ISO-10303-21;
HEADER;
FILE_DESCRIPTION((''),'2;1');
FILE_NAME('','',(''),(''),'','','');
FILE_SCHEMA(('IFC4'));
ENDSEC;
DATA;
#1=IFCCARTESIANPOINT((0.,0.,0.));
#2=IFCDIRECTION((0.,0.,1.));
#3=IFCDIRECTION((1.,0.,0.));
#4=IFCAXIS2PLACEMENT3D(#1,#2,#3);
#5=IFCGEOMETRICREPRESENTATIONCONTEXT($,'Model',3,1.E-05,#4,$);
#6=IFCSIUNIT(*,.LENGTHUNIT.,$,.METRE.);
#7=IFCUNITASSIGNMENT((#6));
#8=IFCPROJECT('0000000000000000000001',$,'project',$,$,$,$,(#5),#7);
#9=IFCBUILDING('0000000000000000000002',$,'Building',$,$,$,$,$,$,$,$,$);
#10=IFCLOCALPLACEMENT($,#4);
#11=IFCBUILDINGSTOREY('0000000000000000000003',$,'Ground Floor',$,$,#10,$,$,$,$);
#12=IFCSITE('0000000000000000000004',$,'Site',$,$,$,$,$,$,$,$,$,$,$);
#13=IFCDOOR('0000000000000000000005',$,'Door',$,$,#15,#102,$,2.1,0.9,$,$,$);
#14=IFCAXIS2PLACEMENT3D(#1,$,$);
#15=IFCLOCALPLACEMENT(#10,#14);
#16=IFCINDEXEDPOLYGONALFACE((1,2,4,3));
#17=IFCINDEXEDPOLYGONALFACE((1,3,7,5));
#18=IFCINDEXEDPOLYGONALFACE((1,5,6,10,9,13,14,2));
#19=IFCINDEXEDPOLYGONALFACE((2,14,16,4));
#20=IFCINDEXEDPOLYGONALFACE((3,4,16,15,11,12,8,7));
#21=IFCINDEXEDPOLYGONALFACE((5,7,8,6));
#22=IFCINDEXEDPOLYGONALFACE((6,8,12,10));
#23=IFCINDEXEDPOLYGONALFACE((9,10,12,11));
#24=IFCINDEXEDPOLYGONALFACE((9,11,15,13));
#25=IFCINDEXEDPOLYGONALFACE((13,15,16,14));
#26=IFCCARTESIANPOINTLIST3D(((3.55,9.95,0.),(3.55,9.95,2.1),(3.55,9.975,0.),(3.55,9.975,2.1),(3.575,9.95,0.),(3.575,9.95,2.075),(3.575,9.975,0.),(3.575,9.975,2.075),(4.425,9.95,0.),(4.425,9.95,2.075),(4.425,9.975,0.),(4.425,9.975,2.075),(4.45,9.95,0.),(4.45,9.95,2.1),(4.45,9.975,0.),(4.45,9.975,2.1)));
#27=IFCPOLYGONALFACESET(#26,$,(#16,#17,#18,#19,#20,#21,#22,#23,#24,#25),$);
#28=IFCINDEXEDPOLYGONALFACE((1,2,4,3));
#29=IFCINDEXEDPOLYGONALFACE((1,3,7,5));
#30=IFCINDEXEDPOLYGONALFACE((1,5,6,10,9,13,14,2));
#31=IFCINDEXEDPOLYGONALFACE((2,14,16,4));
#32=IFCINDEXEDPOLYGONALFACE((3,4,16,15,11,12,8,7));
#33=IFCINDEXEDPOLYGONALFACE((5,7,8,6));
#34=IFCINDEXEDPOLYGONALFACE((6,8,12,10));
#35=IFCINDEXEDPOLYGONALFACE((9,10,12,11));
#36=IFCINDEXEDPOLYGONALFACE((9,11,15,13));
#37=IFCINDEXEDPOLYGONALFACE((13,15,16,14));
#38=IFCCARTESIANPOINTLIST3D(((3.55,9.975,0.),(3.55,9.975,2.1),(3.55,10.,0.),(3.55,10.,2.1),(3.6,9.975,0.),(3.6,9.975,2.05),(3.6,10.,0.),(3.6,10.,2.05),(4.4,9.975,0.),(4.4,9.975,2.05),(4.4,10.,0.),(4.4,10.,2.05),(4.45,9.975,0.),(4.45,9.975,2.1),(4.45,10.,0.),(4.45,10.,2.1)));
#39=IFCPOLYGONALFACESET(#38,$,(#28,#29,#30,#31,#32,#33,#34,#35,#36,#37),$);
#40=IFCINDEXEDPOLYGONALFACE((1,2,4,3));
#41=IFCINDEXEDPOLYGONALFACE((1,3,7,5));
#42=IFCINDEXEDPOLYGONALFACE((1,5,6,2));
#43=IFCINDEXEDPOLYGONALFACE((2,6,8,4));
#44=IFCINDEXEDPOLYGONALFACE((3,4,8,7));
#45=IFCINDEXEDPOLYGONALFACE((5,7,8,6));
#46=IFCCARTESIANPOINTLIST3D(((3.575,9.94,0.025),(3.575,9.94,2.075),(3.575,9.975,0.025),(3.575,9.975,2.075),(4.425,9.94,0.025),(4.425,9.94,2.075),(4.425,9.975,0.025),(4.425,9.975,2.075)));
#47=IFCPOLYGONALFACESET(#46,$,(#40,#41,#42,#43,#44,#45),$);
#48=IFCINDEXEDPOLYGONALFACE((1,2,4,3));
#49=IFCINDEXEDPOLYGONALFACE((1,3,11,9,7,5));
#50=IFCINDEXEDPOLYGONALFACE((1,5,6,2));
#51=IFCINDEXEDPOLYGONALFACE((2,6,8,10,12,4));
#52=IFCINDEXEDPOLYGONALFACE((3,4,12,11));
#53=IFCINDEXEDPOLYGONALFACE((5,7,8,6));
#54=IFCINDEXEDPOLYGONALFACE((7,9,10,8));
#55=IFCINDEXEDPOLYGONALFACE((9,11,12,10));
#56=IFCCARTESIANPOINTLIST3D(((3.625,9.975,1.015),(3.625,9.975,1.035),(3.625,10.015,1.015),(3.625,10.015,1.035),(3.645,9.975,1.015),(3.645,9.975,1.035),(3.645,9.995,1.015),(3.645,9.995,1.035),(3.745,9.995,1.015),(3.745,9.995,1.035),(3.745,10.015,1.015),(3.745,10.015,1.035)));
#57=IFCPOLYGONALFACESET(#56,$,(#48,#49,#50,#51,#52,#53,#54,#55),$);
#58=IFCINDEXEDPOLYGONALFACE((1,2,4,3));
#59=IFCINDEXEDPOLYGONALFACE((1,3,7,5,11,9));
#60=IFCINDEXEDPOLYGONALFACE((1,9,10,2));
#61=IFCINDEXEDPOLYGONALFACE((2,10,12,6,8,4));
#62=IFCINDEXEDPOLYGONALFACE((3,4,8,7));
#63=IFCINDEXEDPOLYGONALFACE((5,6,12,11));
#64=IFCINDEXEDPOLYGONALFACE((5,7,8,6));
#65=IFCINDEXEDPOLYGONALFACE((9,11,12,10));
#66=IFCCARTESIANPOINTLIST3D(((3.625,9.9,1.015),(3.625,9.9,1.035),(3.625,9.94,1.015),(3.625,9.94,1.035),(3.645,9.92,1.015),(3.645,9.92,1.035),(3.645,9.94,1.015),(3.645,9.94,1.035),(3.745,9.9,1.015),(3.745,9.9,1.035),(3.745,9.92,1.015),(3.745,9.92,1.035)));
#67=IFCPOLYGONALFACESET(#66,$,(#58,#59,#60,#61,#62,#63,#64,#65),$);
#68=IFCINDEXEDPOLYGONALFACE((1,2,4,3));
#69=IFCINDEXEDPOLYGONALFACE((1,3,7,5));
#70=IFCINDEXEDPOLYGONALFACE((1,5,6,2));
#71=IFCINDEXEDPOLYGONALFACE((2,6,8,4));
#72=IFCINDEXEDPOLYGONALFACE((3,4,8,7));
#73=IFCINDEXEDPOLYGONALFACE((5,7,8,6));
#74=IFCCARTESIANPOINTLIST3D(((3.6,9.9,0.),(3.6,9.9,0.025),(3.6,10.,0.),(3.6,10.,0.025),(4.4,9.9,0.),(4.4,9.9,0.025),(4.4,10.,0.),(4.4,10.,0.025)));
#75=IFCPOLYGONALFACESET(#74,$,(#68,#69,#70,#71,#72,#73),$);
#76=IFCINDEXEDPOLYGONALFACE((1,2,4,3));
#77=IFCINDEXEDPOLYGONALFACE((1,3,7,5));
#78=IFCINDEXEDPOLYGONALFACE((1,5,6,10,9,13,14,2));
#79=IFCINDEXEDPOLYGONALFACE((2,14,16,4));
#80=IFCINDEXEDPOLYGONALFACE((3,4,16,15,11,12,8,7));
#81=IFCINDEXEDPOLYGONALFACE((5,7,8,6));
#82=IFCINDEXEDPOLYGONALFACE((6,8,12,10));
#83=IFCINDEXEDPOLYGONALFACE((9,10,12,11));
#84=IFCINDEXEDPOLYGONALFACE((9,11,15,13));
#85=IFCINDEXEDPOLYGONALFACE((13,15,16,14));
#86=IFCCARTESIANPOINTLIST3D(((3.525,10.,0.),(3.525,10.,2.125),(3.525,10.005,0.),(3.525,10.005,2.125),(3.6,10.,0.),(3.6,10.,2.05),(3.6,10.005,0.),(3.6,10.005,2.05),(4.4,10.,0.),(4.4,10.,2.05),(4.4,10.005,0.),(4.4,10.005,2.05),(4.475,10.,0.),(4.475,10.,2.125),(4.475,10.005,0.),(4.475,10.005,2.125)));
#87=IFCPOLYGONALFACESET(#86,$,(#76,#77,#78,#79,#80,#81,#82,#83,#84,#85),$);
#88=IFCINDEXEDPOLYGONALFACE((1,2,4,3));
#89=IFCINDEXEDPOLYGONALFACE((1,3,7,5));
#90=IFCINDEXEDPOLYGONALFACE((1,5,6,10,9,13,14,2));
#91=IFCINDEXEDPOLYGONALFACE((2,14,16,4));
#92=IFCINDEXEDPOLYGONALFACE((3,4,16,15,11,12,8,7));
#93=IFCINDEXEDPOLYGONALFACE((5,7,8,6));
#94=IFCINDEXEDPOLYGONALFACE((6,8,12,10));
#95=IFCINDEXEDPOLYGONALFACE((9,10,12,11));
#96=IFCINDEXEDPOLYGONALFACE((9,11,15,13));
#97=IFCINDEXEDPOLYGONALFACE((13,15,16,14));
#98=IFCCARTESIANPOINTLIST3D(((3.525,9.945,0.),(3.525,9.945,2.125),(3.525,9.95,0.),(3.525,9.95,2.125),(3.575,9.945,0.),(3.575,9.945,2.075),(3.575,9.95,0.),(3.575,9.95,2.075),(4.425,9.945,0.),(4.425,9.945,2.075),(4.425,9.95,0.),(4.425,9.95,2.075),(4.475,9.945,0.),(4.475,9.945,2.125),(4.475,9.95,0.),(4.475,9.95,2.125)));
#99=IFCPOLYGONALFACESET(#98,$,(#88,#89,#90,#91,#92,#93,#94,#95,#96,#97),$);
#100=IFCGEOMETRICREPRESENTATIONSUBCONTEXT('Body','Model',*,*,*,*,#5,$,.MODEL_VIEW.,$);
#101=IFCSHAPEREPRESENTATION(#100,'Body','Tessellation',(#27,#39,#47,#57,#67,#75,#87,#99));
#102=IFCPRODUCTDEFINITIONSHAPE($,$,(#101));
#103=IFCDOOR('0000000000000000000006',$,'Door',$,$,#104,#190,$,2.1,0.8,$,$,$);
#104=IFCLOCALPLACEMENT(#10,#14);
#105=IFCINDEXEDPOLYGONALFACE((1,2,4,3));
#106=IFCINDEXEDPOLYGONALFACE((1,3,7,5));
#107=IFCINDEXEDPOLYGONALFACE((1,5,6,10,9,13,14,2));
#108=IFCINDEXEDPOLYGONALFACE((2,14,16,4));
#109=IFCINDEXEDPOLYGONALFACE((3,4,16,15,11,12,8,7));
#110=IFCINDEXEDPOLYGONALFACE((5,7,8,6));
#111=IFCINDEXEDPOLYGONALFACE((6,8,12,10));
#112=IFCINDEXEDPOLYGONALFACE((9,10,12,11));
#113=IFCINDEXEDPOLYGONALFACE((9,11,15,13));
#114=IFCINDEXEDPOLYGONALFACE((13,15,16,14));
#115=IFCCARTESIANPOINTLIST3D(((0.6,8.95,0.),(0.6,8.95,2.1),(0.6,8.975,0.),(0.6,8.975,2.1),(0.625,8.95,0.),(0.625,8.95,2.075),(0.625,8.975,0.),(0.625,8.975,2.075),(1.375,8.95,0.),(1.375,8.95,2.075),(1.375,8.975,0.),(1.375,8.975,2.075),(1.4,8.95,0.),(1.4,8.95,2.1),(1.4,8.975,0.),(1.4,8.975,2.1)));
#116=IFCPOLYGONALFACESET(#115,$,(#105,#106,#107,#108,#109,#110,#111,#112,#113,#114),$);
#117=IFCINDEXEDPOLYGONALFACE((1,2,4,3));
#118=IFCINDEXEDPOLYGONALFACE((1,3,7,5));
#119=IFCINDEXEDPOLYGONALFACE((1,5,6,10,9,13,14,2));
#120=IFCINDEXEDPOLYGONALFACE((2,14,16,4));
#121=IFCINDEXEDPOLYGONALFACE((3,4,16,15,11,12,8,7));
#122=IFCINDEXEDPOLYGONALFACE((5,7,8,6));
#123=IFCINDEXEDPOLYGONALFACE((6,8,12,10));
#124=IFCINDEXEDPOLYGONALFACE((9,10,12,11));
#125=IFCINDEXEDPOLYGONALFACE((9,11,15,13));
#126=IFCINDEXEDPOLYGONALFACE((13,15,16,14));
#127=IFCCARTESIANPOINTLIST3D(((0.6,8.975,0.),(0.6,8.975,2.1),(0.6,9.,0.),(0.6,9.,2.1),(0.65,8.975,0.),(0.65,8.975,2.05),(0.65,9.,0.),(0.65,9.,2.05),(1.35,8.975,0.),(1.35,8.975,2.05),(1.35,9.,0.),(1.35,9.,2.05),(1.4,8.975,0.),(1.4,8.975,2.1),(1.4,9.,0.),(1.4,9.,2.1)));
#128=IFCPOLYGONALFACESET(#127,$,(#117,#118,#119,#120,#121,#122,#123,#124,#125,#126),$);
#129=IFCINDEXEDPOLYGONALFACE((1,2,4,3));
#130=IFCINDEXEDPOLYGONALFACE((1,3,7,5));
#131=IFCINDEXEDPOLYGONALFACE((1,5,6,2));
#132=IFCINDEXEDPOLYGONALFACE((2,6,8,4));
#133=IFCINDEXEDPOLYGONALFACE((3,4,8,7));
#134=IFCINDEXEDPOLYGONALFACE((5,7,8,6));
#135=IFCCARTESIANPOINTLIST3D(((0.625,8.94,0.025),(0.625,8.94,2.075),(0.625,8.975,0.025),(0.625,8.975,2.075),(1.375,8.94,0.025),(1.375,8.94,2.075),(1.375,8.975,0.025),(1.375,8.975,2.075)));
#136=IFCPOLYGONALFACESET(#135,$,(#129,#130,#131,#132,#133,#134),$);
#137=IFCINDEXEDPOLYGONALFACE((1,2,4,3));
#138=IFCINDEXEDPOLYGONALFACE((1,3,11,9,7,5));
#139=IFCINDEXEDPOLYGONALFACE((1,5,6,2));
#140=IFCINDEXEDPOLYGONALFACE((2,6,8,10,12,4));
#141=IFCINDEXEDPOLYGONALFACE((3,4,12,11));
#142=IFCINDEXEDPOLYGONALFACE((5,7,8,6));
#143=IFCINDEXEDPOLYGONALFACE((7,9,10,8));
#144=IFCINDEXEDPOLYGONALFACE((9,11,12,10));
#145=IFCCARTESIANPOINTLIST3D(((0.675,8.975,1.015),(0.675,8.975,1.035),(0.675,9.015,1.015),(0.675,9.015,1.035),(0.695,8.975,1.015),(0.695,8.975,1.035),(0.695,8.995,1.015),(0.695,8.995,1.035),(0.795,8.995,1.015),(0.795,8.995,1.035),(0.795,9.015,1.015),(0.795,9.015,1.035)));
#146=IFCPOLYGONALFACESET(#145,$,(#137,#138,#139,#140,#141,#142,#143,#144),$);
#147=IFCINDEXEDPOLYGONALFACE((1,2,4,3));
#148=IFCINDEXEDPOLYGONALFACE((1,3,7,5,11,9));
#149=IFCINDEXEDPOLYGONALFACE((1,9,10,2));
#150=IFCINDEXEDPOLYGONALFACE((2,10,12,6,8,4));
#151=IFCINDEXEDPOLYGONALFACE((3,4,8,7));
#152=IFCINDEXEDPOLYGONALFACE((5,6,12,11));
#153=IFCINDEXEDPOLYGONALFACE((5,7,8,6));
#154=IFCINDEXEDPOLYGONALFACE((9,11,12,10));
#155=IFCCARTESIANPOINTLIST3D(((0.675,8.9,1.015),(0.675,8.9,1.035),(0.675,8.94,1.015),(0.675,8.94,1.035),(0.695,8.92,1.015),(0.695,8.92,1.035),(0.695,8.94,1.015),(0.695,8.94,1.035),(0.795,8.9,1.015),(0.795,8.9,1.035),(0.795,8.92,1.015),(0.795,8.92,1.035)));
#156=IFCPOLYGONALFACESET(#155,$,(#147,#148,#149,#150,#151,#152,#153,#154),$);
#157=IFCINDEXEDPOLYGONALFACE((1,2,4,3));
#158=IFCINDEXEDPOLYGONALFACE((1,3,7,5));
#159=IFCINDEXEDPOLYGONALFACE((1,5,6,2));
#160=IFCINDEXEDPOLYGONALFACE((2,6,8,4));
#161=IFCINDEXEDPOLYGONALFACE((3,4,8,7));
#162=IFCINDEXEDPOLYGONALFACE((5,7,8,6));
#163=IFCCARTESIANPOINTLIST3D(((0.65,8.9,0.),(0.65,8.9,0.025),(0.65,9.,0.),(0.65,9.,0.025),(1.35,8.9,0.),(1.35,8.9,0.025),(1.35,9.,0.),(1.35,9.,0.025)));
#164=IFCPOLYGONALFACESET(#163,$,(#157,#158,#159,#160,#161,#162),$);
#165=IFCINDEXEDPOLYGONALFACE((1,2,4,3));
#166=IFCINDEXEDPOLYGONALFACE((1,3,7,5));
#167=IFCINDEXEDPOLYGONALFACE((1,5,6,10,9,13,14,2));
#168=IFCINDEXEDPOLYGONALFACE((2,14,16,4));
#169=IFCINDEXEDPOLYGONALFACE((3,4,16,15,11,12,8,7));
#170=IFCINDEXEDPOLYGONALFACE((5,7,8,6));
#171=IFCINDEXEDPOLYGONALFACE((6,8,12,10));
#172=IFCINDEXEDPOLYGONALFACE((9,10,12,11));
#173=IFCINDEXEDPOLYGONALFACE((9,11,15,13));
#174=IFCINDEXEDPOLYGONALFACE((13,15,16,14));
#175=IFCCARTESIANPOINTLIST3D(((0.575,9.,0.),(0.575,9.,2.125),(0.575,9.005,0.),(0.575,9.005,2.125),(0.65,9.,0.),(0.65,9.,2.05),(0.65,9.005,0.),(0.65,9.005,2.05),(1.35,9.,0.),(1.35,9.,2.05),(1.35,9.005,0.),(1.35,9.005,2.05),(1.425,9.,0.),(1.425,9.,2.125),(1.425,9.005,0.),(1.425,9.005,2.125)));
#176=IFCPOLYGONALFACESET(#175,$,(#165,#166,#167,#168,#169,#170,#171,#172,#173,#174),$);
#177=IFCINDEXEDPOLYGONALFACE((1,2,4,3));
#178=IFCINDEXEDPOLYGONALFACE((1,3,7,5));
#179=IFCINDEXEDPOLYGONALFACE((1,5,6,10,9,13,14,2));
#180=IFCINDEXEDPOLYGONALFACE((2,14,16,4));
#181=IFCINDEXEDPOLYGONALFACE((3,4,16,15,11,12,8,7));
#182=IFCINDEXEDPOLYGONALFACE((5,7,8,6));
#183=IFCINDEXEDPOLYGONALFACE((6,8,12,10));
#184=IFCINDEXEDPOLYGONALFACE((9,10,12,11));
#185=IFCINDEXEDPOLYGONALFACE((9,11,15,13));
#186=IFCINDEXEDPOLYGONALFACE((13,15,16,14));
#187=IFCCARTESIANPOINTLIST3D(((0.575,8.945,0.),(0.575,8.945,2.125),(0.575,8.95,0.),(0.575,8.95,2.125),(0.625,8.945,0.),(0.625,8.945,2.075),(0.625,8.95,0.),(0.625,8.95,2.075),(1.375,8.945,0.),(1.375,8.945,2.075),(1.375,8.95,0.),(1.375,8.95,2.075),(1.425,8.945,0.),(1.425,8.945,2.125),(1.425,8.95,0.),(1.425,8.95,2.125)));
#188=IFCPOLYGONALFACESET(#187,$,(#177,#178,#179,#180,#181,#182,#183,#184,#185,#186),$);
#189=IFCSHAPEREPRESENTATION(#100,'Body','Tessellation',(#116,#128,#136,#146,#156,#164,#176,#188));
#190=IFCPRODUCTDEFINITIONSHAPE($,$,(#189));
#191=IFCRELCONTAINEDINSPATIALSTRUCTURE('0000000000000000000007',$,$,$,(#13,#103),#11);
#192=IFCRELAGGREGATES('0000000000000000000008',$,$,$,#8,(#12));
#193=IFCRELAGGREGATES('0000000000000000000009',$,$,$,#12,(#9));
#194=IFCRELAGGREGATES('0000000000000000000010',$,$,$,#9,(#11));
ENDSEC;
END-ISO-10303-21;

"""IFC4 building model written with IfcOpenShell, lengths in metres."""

from ifc_helpers import new_model, si_unit, frame, origin_with_axes, place, context, subcontext, project, spatial, line, indexed_curve, outline, extrude, element, save


model = new_model("IFC4")

# Units and contexts
model_context = context("Model", 3, precision=1e-05, world=origin_with_axes())
body_context = subcontext(model_context, "Body", "Model", "MODEL_VIEW")
ifc_project = project(units=[si_unit("LENGTHUNIT", "METRE")], contexts=[model_context])

# Site, building, storey
site = spatial("IfcSite", under=ifc_project, Name="Site")
building = spatial("IfcBuilding", under=site, Name="Building")
storey_placement = place(None, origin_with_axes())
storey = spatial("IfcBuildingStorey", under=building, at=storey_placement, Name="Ground Floor")

# Doors
door_1_placement = place(storey_placement, frame((4.45, 10.0, 0.0), z_axis=(0.0, 0.0, 1.0), x_axis=(-1.0, 0.0, 0.0)))
element("IfcDoor", 1, at=door_1_placement, inside=storey, Name="Door", OverallHeight=2.1, OverallWidth=0.9, context=body_context, shape_type="SweptSolid", body=[
    extrude(outline(indexed_curve([(0.0, 0.0), (0.0, 2.1), (0.9, 2.1), (0.9, 0.0), (0.875, 0.0), (0.875, 2.075), (0.025, 2.075), (0.025, 0.0)], segments=[line(1, 2, 3, 4, 5, 6, 7, 8, 1)])), frame((0.0, 0.025, 0.0), z_axis=(0.0, -1.0, 0.0), x_axis=(1.0, 0.0, 0.0)), (0.0, 0.0, -1.0), 0.025),
    extrude(outline(indexed_curve([(0.0, 0.0), (0.0, 2.1), (0.9, 2.1), (0.9, 0.0), (0.85, 0.0), (0.85, 2.05), (0.05, 2.05), (0.05, 0.0)], segments=[line(1, 2, 3, 4, 5, 6, 7, 8, 1)])), frame((0.0, 0.0, 0.0), z_axis=(0.0, -1.0, 0.0), x_axis=(1.0, 0.0, 0.0)), (0.0, 0.0, -1.0), 0.025),
    extrude(outline(indexed_curve([(0.0, 0.0), (0.85, 0.0), (0.85, 0.035), (0.0, 0.035)], segments=[line(1, 2, 3, 4, 1)])), frame((0.025, 0.025, 0.025), z_axis=(0.0, 0.0, 1.0), x_axis=(1.0, 0.0, 0.0)), (0.0, 0.0, 1.0), 2.05),
    extrude(outline(indexed_curve([(0.0, 0.0), (0.0, -0.04), (-0.12, -0.04), (-0.12, -0.02), (-0.02, -0.02), (-0.02, 0.0)], segments=[line(1, 2, 3, 4, 5, 6, 1)])), frame((0.825, 0.025, 1.015), z_axis=(0.0, 0.0, 1.0), x_axis=(1.0, 0.0, 0.0)), (0.0, 0.0, 1.0), 0.02),
    extrude(outline(indexed_curve([(0.0, 0.0), (0.0, 0.04), (-0.12, 0.04), (-0.12, 0.02), (-0.02, 0.02), (-0.02, 0.0)], segments=[line(1, 2, 3, 4, 5, 6, 1)])), frame((0.825, 0.06, 1.015), z_axis=(0.0, 0.0, 1.0), x_axis=(1.0, 0.0, 0.0)), (0.0, 0.0, 1.0), 0.02),
    extrude(outline(indexed_curve([(0.0, 0.0), (0.8, 0.0), (0.8, 0.1), (0.0, 0.1)], segments=[line(1, 2, 3, 4, 1)])), frame((0.05, 0.0, 0.0), z_axis=(0.0, 0.0, 1.0), x_axis=(1.0, 0.0, 0.0)), (0.0, 0.0, 1.0), 0.025),
    extrude(outline(indexed_curve([(0.0, 0.0), (0.0, 2.125), (0.95, 2.125), (0.95, 0.0), (0.875, 0.0), (0.875, 2.05), (0.075, 2.05), (0.075, 0.0)], segments=[line(1, 2, 3, 4, 5, 6, 7, 8, 1)])), frame((-0.025, -0.005, 0.0), z_axis=(0.0, -1.0, 0.0), x_axis=(1.0, 0.0, 0.0)), (0.0, 0.0, -1.0), 0.005),
    extrude(outline(indexed_curve([(0.0, 0.0), (0.0, 2.125), (0.95, 2.125), (0.95, 0.0), (0.9, 0.0), (0.9, 2.075), (0.05, 2.075), (0.05, 0.0)], segments=[line(1, 2, 3, 4, 5, 6, 7, 8, 1)])), frame((-0.025, 0.05, 0.0), z_axis=(0.0, -1.0, 0.0), x_axis=(1.0, 0.0, 0.0)), (0.0, 0.0, -1.0), 0.005),
])
door_2_placement = place(storey_placement, frame((1.4, 9.0, 0.0), z_axis=(0.0, 0.0, 1.0), x_axis=(-1.0, 0.0, 0.0)))
element("IfcDoor", 2, at=door_2_placement, inside=storey, Name="Door", OverallHeight=2.1, OverallWidth=0.8, context=body_context, shape_type="SweptSolid", body=[
    extrude(outline(indexed_curve([(0.0, 0.0), (0.0, 2.1), (0.8, 2.1), (0.8, 0.0), (0.775, 0.0), (0.775, 2.075), (0.025, 2.075), (0.025, 0.0)], segments=[line(1, 2, 3, 4, 5, 6, 7, 8, 1)])), frame((0.0, 0.025, 0.0), z_axis=(0.0, -1.0, 0.0), x_axis=(1.0, 0.0, 0.0)), (0.0, 0.0, -1.0), 0.025),
    extrude(outline(indexed_curve([(0.0, 0.0), (0.0, 2.1), (0.8, 2.1), (0.8, 0.0), (0.75, 0.0), (0.75, 2.05), (0.05, 2.05), (0.05, 0.0)], segments=[line(1, 2, 3, 4, 5, 6, 7, 8, 1)])), frame((0.0, 0.0, 0.0), z_axis=(0.0, -1.0, 0.0), x_axis=(1.0, 0.0, 0.0)), (0.0, 0.0, -1.0), 0.025),
    extrude(outline(indexed_curve([(0.0, 0.0), (0.75, 0.0), (0.75, 0.035), (0.0, 0.035)], segments=[line(1, 2, 3, 4, 1)])), frame((0.025, 0.025, 0.025), z_axis=(0.0, 0.0, 1.0), x_axis=(1.0, 0.0, 0.0)), (0.0, 0.0, 1.0), 2.05),
    extrude(outline(indexed_curve([(0.0, 0.0), (0.0, -0.04), (-0.12, -0.04), (-0.12, -0.02), (-0.02, -0.02), (-0.02, 0.0)], segments=[line(1, 2, 3, 4, 5, 6, 1)])), frame((0.725, 0.025, 1.015), z_axis=(0.0, 0.0, 1.0), x_axis=(1.0, 0.0, 0.0)), (0.0, 0.0, 1.0), 0.02),
    extrude(outline(indexed_curve([(0.0, 0.0), (0.0, 0.04), (-0.12, 0.04), (-0.12, 0.02), (-0.02, 0.02), (-0.02, 0.0)], segments=[line(1, 2, 3, 4, 5, 6, 1)])), frame((0.725, 0.06, 1.015), z_axis=(0.0, 0.0, 1.0), x_axis=(1.0, 0.0, 0.0)), (0.0, 0.0, 1.0), 0.02),
    extrude(outline(indexed_curve([(0.0, 0.0), (0.7, 0.0), (0.7, 0.1), (0.0, 0.1)], segments=[line(1, 2, 3, 4, 1)])), frame((0.05, 0.0, 0.0), z_axis=(0.0, 0.0, 1.0), x_axis=(1.0, 0.0, 0.0)), (0.0, 0.0, 1.0), 0.025),
    extrude(outline(indexed_curve([(0.0, 0.0), (0.0, 2.125), (0.85, 2.125), (0.85, 0.0), (0.775, 0.0), (0.775, 2.05), (0.075, 2.05), (0.075, 0.0)], segments=[line(1, 2, 3, 4, 5, 6, 7, 8, 1)])), frame((-0.025, -0.005, 0.0), z_axis=(0.0, -1.0, 0.0), x_axis=(1.0, 0.0, 0.0)), (0.0, 0.0, -1.0), 0.005),
    extrude(outline(indexed_curve([(0.0, 0.0), (0.0, 2.125), (0.85, 2.125), (0.85, 0.0), (0.8, 0.0), (0.8, 2.075), (0.05, 2.075), (0.05, 0.0)], segments=[line(1, 2, 3, 4, 5, 6, 7, 8, 1)])), frame((-0.025, 0.05, 0.0), z_axis=(0.0, -1.0, 0.0), x_axis=(1.0, 0.0, 0.0)), (0.0, 0.0, -1.0), 0.005),
])

save(model, "model.ifc")
